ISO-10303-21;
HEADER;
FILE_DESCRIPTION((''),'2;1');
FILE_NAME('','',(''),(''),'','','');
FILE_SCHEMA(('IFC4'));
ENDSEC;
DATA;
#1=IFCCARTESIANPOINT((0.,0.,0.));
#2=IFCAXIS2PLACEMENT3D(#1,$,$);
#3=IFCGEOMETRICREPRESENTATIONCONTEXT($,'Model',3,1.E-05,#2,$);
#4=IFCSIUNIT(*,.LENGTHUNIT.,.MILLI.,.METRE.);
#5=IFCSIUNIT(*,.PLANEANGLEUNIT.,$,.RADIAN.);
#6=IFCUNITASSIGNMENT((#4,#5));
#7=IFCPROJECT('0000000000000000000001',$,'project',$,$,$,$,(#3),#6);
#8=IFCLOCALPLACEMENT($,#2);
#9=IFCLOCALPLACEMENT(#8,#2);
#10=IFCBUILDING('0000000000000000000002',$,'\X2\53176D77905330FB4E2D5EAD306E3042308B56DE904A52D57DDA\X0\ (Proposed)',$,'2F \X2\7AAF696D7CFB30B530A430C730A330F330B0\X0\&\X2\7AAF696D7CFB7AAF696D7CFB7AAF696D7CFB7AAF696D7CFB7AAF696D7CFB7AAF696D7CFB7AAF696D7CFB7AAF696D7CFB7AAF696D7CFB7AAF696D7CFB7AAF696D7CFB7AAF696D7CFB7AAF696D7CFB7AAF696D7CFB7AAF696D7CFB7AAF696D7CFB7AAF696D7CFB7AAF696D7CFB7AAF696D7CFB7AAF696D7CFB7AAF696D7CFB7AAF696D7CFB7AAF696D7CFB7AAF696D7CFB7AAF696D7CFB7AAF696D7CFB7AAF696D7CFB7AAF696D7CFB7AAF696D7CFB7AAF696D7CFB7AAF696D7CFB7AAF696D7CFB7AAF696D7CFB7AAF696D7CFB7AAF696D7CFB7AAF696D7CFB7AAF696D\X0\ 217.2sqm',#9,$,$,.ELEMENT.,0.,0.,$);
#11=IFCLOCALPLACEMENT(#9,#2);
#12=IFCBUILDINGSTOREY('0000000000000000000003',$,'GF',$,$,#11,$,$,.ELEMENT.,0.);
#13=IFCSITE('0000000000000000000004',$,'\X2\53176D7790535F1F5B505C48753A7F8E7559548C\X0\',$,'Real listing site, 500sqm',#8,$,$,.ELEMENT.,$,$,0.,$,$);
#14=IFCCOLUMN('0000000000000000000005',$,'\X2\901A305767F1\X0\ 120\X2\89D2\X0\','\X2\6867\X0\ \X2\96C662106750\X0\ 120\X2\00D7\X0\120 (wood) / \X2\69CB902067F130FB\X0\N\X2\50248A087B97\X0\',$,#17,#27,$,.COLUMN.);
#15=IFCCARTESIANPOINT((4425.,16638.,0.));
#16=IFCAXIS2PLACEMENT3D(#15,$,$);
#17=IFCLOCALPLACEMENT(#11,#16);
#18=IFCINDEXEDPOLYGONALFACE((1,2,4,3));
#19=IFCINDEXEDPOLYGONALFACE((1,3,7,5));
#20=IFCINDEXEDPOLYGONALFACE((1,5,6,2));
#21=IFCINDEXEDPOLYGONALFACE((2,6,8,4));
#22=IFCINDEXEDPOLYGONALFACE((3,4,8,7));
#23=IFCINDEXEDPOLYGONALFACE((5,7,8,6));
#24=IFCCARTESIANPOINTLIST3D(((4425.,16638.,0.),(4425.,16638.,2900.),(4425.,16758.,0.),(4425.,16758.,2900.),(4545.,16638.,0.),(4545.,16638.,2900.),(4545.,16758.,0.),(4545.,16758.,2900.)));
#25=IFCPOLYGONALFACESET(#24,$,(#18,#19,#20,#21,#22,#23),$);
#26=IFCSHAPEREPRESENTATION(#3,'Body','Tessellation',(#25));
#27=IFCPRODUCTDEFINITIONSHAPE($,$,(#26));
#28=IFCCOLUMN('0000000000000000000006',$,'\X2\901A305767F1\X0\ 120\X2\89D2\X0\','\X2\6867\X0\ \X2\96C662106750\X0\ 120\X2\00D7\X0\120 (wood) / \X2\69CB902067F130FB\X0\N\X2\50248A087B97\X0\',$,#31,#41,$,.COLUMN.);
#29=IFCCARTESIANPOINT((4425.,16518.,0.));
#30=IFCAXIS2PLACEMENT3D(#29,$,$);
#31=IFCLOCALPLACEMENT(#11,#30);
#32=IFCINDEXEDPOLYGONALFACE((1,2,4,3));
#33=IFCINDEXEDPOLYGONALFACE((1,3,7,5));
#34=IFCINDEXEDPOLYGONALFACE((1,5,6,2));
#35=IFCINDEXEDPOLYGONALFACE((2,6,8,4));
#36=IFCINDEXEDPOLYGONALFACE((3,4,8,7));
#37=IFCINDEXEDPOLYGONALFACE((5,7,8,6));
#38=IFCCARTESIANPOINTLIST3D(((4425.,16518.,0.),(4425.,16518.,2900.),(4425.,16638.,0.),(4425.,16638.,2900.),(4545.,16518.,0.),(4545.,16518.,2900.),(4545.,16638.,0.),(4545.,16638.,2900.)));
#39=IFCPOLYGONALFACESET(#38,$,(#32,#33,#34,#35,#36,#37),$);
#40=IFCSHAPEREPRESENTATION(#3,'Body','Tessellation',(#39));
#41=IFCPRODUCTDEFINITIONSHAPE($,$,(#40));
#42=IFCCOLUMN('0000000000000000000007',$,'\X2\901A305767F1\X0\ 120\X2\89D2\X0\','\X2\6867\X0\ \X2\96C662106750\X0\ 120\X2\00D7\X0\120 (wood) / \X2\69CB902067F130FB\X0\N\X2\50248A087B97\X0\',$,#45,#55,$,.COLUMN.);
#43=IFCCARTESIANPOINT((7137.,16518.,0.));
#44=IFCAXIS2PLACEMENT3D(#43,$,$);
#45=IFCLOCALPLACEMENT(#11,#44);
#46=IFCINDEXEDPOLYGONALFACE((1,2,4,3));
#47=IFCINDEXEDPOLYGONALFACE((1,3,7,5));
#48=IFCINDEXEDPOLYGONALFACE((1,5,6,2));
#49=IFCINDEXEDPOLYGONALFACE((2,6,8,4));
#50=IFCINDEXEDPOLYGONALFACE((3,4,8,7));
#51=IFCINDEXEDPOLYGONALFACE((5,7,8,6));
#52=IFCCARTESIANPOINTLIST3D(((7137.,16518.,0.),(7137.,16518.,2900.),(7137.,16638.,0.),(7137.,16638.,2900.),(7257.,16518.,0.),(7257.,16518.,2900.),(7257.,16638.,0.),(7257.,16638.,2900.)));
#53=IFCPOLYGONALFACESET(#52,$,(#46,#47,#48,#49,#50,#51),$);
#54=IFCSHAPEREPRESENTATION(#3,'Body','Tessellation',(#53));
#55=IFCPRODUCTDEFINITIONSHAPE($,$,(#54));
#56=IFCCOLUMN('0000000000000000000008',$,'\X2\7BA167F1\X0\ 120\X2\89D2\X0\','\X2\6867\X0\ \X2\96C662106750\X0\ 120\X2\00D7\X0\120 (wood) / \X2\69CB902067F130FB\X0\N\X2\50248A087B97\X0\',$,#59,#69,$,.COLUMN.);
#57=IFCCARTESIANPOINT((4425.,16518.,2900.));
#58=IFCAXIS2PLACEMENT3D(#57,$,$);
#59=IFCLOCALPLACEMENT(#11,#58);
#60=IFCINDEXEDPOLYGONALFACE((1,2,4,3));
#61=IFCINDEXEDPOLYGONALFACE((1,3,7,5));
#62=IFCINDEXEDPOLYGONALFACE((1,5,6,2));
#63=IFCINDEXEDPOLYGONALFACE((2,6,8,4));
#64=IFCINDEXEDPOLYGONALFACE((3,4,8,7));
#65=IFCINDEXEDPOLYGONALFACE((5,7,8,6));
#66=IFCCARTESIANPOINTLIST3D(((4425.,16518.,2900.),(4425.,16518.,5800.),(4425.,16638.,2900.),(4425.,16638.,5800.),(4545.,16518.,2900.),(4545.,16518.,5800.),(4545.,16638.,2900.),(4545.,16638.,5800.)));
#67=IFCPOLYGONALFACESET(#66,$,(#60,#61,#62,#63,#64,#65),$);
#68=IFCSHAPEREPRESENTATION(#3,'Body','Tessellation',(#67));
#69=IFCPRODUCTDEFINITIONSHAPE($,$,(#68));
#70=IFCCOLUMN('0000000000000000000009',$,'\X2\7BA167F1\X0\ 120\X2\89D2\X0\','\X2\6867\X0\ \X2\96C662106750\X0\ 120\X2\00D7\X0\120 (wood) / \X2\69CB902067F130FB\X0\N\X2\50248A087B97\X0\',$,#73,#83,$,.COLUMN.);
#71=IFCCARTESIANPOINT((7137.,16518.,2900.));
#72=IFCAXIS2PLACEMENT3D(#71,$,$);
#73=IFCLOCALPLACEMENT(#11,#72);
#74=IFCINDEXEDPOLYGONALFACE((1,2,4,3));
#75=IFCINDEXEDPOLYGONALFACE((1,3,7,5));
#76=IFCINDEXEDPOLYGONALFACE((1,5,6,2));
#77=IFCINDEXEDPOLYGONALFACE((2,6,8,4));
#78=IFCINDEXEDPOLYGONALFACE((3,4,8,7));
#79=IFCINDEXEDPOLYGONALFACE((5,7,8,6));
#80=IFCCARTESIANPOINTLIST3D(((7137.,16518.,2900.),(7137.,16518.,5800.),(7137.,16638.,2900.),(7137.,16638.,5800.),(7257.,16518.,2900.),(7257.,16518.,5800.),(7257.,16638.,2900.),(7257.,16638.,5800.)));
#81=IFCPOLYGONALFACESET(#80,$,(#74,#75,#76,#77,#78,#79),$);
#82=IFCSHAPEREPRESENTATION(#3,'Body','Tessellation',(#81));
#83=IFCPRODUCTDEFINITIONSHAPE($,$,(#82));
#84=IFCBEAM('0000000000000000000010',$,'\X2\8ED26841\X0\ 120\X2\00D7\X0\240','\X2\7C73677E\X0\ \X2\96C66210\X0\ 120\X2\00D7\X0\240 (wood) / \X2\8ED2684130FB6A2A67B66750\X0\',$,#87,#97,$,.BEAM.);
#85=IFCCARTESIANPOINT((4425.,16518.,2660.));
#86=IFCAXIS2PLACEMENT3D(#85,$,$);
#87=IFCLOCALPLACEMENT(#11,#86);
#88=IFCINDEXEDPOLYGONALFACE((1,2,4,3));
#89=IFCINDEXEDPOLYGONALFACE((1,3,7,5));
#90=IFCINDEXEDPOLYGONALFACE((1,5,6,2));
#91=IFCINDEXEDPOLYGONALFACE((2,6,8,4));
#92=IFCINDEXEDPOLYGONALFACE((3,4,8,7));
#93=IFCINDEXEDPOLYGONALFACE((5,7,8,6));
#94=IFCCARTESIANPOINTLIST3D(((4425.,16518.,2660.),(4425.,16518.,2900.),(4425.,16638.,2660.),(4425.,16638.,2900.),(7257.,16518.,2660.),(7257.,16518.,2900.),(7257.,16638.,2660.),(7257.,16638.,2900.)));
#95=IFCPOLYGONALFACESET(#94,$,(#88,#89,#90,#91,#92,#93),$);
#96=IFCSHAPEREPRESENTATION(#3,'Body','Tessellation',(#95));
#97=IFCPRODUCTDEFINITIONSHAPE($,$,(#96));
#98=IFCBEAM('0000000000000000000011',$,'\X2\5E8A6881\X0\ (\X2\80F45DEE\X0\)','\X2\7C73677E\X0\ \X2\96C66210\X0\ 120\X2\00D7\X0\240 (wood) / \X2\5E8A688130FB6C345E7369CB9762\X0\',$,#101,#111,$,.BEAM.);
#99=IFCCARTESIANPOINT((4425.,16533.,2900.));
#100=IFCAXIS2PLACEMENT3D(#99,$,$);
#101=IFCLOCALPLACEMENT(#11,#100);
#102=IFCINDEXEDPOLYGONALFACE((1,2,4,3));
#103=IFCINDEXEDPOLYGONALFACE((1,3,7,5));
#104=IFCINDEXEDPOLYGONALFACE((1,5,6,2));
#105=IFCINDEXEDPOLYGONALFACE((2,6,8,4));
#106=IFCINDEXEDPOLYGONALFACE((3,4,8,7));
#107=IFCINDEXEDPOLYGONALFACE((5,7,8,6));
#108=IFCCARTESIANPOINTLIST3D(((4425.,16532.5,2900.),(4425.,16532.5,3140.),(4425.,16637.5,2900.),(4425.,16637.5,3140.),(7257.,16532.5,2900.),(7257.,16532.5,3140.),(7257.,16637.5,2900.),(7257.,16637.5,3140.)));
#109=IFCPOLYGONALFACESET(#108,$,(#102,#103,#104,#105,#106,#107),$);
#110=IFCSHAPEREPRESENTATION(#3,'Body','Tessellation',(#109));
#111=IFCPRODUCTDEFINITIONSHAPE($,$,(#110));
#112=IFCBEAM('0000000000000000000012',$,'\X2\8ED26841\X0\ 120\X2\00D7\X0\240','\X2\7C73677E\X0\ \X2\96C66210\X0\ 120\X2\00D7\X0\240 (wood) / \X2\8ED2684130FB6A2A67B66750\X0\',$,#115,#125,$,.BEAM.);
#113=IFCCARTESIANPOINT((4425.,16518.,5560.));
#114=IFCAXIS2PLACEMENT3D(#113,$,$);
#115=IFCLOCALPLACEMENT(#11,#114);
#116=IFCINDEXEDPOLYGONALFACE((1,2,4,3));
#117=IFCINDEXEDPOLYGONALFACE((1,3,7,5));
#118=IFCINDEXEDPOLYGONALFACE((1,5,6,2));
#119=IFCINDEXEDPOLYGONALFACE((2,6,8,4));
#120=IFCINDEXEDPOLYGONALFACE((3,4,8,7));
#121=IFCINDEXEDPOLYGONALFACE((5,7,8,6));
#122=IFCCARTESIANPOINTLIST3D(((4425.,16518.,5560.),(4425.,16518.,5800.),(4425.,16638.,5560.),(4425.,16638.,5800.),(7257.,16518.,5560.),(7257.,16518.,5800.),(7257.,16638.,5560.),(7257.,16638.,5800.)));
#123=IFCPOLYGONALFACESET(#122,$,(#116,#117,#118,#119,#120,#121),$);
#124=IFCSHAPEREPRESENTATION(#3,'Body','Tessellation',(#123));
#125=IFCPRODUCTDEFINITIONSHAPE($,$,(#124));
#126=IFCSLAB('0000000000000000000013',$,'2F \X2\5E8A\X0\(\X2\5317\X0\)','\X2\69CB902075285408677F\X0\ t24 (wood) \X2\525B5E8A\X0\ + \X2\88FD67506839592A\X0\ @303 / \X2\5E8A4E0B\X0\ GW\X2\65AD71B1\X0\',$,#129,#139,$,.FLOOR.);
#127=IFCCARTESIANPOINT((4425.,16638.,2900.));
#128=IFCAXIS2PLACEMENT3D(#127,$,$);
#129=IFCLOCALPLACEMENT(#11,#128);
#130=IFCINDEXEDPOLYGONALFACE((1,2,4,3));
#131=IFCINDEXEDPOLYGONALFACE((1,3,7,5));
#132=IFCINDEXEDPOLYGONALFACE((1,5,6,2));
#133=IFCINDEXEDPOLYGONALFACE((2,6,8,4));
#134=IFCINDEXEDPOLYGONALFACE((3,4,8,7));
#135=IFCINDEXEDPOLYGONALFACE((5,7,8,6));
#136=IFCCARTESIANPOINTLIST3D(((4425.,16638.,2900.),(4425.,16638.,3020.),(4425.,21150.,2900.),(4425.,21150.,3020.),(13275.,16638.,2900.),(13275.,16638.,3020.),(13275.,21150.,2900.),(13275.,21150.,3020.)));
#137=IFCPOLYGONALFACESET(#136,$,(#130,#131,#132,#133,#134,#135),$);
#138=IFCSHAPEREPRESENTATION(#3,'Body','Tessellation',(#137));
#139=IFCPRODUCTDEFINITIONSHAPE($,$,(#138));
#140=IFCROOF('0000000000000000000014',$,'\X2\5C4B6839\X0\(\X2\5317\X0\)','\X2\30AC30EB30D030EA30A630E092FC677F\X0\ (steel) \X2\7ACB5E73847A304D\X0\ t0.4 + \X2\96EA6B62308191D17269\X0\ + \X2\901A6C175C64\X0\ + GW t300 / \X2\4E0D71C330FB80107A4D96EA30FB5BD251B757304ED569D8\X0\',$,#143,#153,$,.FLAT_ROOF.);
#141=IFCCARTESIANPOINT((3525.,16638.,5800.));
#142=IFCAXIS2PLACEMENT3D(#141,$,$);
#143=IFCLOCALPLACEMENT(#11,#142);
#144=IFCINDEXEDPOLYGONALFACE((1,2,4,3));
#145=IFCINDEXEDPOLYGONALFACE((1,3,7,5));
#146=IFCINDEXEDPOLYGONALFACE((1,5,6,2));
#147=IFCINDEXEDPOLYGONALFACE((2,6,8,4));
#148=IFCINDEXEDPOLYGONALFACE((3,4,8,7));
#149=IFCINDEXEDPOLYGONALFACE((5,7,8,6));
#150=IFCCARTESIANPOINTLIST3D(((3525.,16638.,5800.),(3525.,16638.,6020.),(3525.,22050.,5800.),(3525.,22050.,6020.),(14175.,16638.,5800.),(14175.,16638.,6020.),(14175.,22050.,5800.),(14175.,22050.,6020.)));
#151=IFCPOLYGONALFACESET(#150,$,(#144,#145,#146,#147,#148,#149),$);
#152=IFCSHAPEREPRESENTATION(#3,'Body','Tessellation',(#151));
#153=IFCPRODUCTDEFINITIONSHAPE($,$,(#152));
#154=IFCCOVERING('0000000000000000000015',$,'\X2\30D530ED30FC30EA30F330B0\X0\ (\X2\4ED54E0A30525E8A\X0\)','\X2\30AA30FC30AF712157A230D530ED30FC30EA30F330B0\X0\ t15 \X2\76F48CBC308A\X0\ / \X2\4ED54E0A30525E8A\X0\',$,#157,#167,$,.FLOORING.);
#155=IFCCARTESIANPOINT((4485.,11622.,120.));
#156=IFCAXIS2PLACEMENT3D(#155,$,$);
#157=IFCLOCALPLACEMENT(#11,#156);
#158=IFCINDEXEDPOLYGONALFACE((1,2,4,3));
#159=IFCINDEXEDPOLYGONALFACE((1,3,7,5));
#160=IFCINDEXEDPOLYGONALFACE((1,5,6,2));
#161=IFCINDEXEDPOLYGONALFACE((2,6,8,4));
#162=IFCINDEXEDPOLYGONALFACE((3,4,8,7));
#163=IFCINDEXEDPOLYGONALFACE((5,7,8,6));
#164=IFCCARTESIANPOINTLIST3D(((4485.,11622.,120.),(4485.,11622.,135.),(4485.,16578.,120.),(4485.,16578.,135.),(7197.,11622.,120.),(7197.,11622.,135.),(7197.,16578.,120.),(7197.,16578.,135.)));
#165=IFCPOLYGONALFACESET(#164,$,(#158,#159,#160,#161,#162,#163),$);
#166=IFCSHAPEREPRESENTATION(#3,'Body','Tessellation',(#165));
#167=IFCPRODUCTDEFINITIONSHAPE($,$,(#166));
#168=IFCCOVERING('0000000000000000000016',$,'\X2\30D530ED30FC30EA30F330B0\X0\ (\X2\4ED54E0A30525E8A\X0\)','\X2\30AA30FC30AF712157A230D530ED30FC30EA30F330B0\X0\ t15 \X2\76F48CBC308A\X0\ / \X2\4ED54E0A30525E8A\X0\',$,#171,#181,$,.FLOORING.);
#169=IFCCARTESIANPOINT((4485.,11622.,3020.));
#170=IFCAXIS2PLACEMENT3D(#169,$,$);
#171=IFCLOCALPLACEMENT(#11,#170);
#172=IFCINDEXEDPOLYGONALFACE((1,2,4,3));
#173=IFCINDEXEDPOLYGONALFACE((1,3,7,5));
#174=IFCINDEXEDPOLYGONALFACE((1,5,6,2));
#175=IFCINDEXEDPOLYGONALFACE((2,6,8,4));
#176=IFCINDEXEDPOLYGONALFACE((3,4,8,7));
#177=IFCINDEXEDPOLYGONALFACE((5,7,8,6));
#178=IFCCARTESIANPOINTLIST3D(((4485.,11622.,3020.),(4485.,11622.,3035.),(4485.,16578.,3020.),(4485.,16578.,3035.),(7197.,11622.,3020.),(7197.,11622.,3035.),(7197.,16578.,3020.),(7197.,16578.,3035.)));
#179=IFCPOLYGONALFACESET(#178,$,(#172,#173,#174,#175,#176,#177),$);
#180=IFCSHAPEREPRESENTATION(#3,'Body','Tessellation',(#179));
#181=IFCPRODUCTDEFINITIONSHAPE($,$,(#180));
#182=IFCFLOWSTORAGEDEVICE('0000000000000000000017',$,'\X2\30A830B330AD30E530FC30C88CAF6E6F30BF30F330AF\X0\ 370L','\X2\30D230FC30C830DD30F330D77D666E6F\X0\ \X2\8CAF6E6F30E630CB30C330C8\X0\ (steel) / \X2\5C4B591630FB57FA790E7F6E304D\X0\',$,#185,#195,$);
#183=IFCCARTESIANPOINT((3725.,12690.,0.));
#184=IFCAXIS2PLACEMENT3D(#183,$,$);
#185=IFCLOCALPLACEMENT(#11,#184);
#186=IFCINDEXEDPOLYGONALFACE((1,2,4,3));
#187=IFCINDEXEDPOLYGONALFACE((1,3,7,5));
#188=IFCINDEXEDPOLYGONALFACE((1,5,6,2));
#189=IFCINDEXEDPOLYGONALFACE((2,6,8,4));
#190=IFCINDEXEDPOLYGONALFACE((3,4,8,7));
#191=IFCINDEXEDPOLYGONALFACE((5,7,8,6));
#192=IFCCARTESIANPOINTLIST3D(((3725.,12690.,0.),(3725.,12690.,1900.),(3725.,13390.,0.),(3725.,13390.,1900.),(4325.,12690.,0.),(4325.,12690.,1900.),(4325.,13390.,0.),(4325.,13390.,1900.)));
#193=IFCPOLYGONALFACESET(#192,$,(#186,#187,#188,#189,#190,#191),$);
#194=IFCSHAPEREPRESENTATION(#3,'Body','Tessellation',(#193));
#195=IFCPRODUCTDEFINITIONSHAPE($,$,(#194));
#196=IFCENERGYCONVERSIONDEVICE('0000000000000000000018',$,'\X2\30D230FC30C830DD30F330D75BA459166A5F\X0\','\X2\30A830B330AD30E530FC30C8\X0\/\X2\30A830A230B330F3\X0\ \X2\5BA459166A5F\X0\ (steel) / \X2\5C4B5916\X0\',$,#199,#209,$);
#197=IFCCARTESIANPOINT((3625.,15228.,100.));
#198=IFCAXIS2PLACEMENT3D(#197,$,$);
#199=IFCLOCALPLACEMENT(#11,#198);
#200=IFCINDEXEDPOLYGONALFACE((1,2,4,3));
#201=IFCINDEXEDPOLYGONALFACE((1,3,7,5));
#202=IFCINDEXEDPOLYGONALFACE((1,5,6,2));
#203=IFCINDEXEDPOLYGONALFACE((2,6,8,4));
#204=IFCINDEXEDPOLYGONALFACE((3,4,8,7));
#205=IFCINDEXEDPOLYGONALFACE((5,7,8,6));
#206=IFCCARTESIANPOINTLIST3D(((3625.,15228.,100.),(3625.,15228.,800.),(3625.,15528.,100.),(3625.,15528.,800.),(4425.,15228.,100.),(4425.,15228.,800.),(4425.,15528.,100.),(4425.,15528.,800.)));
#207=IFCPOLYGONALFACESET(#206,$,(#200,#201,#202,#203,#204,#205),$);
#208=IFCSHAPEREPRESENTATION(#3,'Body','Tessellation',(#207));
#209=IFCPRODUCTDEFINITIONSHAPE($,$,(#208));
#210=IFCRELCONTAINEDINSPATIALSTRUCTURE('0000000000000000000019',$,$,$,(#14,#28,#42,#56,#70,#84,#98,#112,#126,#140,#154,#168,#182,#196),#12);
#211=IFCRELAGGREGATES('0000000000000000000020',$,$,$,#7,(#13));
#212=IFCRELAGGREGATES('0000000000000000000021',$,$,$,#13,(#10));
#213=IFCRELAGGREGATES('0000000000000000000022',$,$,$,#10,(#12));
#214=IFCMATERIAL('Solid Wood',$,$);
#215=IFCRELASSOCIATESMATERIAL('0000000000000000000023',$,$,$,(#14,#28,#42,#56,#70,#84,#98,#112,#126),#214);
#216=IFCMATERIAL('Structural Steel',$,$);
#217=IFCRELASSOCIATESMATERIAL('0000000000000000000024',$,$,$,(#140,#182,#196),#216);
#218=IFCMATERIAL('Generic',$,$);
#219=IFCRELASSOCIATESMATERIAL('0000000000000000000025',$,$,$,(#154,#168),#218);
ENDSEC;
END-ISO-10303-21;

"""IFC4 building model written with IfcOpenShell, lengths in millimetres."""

from ifc_helpers import new_model, si_unit, frame, frame_2d, origin, place, context, project, spatial, rectangle, extrude, material, element, save


model = new_model("IFC4")

# Units and contexts
model_context = context("Model", 3, precision=1e-05, world=origin())
ifc_project = project(units=[si_unit("LENGTHUNIT", "METRE", prefix="MILLI"), si_unit("PLANEANGLEUNIT", "RADIAN")], contexts=[model_context])

# Site, building, storey
site_placement = place(None, origin())
site = spatial("IfcSite", under=ifc_project, at=site_placement, Name="北海道弟子屈町美留和", ObjectType="Real listing site, 500sqm", CompositionType="ELEMENT", RefElevation=0.0)
building_placement = place(site_placement, origin())
building = spatial("IfcBuilding", under=site, at=building_placement, Name="北海道・中庭のある回遊動線 (Proposed)", ObjectType="2F 窯業系サイディング&窯業系窯業系窯業系窯業系窯業系窯業系窯業系窯業系窯業系窯業系窯業系窯業系窯業系窯業系窯業系窯業系窯業系窯業系窯業系窯業系窯業系窯業系窯業系窯業系窯業系窯業系窯業系窯業系窯業系窯業系窯業系窯業系窯業系窯業系窯業系窯業系窯業 217.2sqm", CompositionType="ELEMENT", ElevationOfRefHeight=0.0, ElevationOfTerrain=0.0)
storey_placement = place(building_placement, origin())
storey = spatial("IfcBuildingStorey", under=building, at=storey_placement, Name="GF", CompositionType="ELEMENT", Elevation=0.0)

# Columns
ifc_material_1 = material(Name="Solid Wood")
column_1_placement = place(storey_placement, frame((4425.0, 16638.0, 0.0)))
element("IfcColumn", 1, at=column_1_placement, inside=storey, material=ifc_material_1, Name="通し柱 120角", Description="桧 集成材 120×120 (wood) / 構造柱・N値計算", PredefinedType="COLUMN", context=model_context, shape_type="SweptSolid", body=[
    extrude(rectangle(XDim=120.0, YDim=120.0, at=frame_2d((60.0, 60.0))), frame((4425.0, 16638.0, 0.0)), (0.0, 0.0, 1.0), 2900.0),
])
column_2_placement = place(storey_placement, frame((4425.0, 16518.0, 0.0)))
element("IfcColumn", 2, at=column_2_placement, inside=storey, material=ifc_material_1, Name="通し柱 120角", Description="桧 集成材 120×120 (wood) / 構造柱・N値計算", PredefinedType="COLUMN", context=model_context, shape_type="SweptSolid", body=[
    extrude(rectangle(XDim=120.0, YDim=120.0, at=frame_2d((60.0, 60.0))), frame((4425.0, 16518.0, 0.0)), (0.0, 0.0, 1.0), 2900.0),
])
column_3_placement = place(storey_placement, frame((7137.0, 16518.0, 0.0)))
element("IfcColumn", 3, at=column_3_placement, inside=storey, material=ifc_material_1, Name="通し柱 120角", Description="桧 集成材 120×120 (wood) / 構造柱・N値計算", PredefinedType="COLUMN", context=model_context, shape_type="SweptSolid", body=[
    extrude(rectangle(XDim=120.0, YDim=120.0, at=frame_2d((60.0, 60.0))), frame((7137.0, 16518.0, 0.0)), (0.0, 0.0, 1.0), 2900.0),
])
column_4_placement = place(storey_placement, frame((4425.0, 16518.0, 2900.0)))
element("IfcColumn", 4, at=column_4_placement, inside=storey, material=ifc_material_1, Name="管柱 120角", Description="桧 集成材 120×120 (wood) / 構造柱・N値計算", PredefinedType="COLUMN", context=model_context, shape_type="SweptSolid", body=[
    extrude(rectangle(XDim=120.0, YDim=120.0, at=frame_2d((60.0, 60.0))), frame((4425.0, 16518.0, 2900.0)), (0.0, 0.0, 1.0), 2900.0),
])
column_5_placement = place(storey_placement, frame((7137.0, 16518.0, 2900.0)))
element("IfcColumn", 5, at=column_5_placement, inside=storey, material=ifc_material_1, Name="管柱 120角", Description="桧 集成材 120×120 (wood) / 構造柱・N値計算", PredefinedType="COLUMN", context=model_context, shape_type="SweptSolid", body=[
    extrude(rectangle(XDim=120.0, YDim=120.0, at=frame_2d((60.0, 60.0))), frame((7137.0, 16518.0, 2900.0)), (0.0, 0.0, 1.0), 2900.0),
])

# Beams
beam_1_placement = place(storey_placement, frame((4425.0, 16518.0, 2660.0)))
element("IfcBeam", 6, at=beam_1_placement, inside=storey, material=ifc_material_1, Name="軒桁 120×240", Description="米松 集成 120×240 (wood) / 軒桁・横架材", PredefinedType="BEAM", context=model_context, shape_type="SweptSolid", body=[
    extrude(rectangle(XDim=2832.0, YDim=120.0, at=frame_2d((1416.0, 60.0))), frame((4425.0, 16518.0, 2660.0)), (0.0, 0.0, 1.0), 240.0),
])
beam_2_placement = place(storey_placement, frame((4425.0, 16533.0, 2900.0)))
element("IfcBeam", 7, at=beam_2_placement, inside=storey, material=ifc_material_1, Name="床梁 (胴差)", Description="米松 集成 120×240 (wood) / 床梁・水平構面", PredefinedType="BEAM", context=model_context, shape_type="SweptSolid", body=[
    extrude(rectangle(XDim=2832.0, YDim=105.0, at=frame_2d((1416.0, 52.0))), frame((4425.0, 16533.0, 2900.0)), (0.0, 0.0, 1.0), 240.0),
])
beam_3_placement = place(storey_placement, frame((4425.0, 16518.0, 5560.0)))
element("IfcBeam", 8, at=beam_3_placement, inside=storey, material=ifc_material_1, Name="軒桁 120×240", Description="米松 集成 120×240 (wood) / 軒桁・横架材", PredefinedType="BEAM", context=model_context, shape_type="SweptSolid", body=[
    extrude(rectangle(XDim=2832.0, YDim=120.0, at=frame_2d((1416.0, 60.0))), frame((4425.0, 16518.0, 5560.0)), (0.0, 0.0, 1.0), 240.0),
])

# Slab
slab_1_placement = place(storey_placement, frame((4425.0, 16638.0, 2900.0)))
element("IfcSlab", 9, at=slab_1_placement, inside=storey, material=ifc_material_1, Name="2F 床(北)", Description="構造用合板 t24 (wood) 剛床 + 製材根太 @303 / 床下 GW断熱", PredefinedType="FLOOR", context=model_context, shape_type="SweptSolid", body=[
    extrude(rectangle(XDim=8850.0, YDim=4512.0, at=frame_2d((4425.0, 2256.0))), frame((4425.0, 16638.0, 2900.0)), (0.0, 0.0, 1.0), 120.0),
])

# Roof
ifc_material_2 = material(Name="Structural Steel")
for number, where, name in (
    (10, (3525.0, 16638.0, 5800.0), "屋根(北)"),
):
    element("IfcRoof", number, at=place(storey_placement, frame(where)), inside=storey, material=ifc_material_2, Name=name, Description="ガルバリウム鋼板 (steel) 立平葺き t0.4 + 雪止め金物 + 通気層 + GW t300 / 不燃・耐積雪・寒冷地仕様", PredefinedType="FLAT_ROOF", context=model_context, shape_type="SweptSolid", body=[
        extrude(rectangle(XDim=10650.0, YDim=5412.0, at=frame_2d((5325.0, 2706.0))), frame((3525.0, 16638.0, 5800.0)), (0.0, 0.0, 1.0), 220.0),
    ])

# Coverings
ifc_material_3 = material(Name="Generic")
covering_1_placement = place(storey_placement, frame((4485.0, 11622.0, 120.0)))
element("IfcCovering", 11, at=covering_1_placement, inside=storey, material=ifc_material_3, Name="フローリング (仕上げ床)", Description="オーク無垢フローリング t15 直貼り / 仕上げ床", PredefinedType="FLOORING", context=model_context, shape_type="SweptSolid", body=[
    extrude(rectangle(XDim=2712.0, YDim=4956.0, at=frame_2d((1356.0, 2478.0))), frame((4485.0, 11622.0, 120.0)), (0.0, 0.0, 1.0), 15.0),
])
covering_2_placement = place(storey_placement, frame((4485.0, 11622.0, 3020.0)))
element("IfcCovering", 12, at=covering_2_placement, inside=storey, material=ifc_material_3, Name="フローリング (仕上げ床)", Description="オーク無垢フローリング t15 直貼り / 仕上げ床", PredefinedType="FLOORING", context=model_context, shape_type="SweptSolid", body=[
    extrude(rectangle(XDim=2712.0, YDim=4956.0, at=frame_2d((1356.0, 2478.0))), frame((4485.0, 11622.0, 3020.0)), (0.0, 0.0, 1.0), 15.0),
])

# Flow storage device
flow_storage_device_placement = place(storey_placement, frame((3725.0, 12690.0, 0.0)))
element("IfcFlowStorageDevice", 13, at=flow_storage_device_placement, inside=storey, material=ifc_material_2, Name="エコキュート貯湯タンク 370L", Description="ヒートポンプ給湯 貯湯ユニット (steel) / 屋外・基礎置き", context=model_context, shape_type="SweptSolid", body=[
    extrude(rectangle(XDim=600.0, YDim=700.0, at=frame_2d((300.0, 350.0))), frame((3725.0, 12690.0, 0.0)), (0.0, 0.0, 1.0), 1900.0),
])

# Energy conversion device
energy_conversion_device_placement = place(storey_placement, frame((3625.0, 15228.0, 100.0)))
element("IfcEnergyConversionDevice", 14, at=energy_conversion_device_placement, inside=storey, material=ifc_material_2, Name="ヒートポンプ室外機", Description="エコキュート/エアコン 室外機 (steel) / 屋外", context=model_context, shape_type="SweptSolid", body=[
    extrude(rectangle(XDim=800.0, YDim=300.0, at=frame_2d((400.0, 150.0))), frame((3625.0, 15228.0, 100.0)), (0.0, 0.0, 1.0), 700.0),
])

save(model, "model.ifc")
